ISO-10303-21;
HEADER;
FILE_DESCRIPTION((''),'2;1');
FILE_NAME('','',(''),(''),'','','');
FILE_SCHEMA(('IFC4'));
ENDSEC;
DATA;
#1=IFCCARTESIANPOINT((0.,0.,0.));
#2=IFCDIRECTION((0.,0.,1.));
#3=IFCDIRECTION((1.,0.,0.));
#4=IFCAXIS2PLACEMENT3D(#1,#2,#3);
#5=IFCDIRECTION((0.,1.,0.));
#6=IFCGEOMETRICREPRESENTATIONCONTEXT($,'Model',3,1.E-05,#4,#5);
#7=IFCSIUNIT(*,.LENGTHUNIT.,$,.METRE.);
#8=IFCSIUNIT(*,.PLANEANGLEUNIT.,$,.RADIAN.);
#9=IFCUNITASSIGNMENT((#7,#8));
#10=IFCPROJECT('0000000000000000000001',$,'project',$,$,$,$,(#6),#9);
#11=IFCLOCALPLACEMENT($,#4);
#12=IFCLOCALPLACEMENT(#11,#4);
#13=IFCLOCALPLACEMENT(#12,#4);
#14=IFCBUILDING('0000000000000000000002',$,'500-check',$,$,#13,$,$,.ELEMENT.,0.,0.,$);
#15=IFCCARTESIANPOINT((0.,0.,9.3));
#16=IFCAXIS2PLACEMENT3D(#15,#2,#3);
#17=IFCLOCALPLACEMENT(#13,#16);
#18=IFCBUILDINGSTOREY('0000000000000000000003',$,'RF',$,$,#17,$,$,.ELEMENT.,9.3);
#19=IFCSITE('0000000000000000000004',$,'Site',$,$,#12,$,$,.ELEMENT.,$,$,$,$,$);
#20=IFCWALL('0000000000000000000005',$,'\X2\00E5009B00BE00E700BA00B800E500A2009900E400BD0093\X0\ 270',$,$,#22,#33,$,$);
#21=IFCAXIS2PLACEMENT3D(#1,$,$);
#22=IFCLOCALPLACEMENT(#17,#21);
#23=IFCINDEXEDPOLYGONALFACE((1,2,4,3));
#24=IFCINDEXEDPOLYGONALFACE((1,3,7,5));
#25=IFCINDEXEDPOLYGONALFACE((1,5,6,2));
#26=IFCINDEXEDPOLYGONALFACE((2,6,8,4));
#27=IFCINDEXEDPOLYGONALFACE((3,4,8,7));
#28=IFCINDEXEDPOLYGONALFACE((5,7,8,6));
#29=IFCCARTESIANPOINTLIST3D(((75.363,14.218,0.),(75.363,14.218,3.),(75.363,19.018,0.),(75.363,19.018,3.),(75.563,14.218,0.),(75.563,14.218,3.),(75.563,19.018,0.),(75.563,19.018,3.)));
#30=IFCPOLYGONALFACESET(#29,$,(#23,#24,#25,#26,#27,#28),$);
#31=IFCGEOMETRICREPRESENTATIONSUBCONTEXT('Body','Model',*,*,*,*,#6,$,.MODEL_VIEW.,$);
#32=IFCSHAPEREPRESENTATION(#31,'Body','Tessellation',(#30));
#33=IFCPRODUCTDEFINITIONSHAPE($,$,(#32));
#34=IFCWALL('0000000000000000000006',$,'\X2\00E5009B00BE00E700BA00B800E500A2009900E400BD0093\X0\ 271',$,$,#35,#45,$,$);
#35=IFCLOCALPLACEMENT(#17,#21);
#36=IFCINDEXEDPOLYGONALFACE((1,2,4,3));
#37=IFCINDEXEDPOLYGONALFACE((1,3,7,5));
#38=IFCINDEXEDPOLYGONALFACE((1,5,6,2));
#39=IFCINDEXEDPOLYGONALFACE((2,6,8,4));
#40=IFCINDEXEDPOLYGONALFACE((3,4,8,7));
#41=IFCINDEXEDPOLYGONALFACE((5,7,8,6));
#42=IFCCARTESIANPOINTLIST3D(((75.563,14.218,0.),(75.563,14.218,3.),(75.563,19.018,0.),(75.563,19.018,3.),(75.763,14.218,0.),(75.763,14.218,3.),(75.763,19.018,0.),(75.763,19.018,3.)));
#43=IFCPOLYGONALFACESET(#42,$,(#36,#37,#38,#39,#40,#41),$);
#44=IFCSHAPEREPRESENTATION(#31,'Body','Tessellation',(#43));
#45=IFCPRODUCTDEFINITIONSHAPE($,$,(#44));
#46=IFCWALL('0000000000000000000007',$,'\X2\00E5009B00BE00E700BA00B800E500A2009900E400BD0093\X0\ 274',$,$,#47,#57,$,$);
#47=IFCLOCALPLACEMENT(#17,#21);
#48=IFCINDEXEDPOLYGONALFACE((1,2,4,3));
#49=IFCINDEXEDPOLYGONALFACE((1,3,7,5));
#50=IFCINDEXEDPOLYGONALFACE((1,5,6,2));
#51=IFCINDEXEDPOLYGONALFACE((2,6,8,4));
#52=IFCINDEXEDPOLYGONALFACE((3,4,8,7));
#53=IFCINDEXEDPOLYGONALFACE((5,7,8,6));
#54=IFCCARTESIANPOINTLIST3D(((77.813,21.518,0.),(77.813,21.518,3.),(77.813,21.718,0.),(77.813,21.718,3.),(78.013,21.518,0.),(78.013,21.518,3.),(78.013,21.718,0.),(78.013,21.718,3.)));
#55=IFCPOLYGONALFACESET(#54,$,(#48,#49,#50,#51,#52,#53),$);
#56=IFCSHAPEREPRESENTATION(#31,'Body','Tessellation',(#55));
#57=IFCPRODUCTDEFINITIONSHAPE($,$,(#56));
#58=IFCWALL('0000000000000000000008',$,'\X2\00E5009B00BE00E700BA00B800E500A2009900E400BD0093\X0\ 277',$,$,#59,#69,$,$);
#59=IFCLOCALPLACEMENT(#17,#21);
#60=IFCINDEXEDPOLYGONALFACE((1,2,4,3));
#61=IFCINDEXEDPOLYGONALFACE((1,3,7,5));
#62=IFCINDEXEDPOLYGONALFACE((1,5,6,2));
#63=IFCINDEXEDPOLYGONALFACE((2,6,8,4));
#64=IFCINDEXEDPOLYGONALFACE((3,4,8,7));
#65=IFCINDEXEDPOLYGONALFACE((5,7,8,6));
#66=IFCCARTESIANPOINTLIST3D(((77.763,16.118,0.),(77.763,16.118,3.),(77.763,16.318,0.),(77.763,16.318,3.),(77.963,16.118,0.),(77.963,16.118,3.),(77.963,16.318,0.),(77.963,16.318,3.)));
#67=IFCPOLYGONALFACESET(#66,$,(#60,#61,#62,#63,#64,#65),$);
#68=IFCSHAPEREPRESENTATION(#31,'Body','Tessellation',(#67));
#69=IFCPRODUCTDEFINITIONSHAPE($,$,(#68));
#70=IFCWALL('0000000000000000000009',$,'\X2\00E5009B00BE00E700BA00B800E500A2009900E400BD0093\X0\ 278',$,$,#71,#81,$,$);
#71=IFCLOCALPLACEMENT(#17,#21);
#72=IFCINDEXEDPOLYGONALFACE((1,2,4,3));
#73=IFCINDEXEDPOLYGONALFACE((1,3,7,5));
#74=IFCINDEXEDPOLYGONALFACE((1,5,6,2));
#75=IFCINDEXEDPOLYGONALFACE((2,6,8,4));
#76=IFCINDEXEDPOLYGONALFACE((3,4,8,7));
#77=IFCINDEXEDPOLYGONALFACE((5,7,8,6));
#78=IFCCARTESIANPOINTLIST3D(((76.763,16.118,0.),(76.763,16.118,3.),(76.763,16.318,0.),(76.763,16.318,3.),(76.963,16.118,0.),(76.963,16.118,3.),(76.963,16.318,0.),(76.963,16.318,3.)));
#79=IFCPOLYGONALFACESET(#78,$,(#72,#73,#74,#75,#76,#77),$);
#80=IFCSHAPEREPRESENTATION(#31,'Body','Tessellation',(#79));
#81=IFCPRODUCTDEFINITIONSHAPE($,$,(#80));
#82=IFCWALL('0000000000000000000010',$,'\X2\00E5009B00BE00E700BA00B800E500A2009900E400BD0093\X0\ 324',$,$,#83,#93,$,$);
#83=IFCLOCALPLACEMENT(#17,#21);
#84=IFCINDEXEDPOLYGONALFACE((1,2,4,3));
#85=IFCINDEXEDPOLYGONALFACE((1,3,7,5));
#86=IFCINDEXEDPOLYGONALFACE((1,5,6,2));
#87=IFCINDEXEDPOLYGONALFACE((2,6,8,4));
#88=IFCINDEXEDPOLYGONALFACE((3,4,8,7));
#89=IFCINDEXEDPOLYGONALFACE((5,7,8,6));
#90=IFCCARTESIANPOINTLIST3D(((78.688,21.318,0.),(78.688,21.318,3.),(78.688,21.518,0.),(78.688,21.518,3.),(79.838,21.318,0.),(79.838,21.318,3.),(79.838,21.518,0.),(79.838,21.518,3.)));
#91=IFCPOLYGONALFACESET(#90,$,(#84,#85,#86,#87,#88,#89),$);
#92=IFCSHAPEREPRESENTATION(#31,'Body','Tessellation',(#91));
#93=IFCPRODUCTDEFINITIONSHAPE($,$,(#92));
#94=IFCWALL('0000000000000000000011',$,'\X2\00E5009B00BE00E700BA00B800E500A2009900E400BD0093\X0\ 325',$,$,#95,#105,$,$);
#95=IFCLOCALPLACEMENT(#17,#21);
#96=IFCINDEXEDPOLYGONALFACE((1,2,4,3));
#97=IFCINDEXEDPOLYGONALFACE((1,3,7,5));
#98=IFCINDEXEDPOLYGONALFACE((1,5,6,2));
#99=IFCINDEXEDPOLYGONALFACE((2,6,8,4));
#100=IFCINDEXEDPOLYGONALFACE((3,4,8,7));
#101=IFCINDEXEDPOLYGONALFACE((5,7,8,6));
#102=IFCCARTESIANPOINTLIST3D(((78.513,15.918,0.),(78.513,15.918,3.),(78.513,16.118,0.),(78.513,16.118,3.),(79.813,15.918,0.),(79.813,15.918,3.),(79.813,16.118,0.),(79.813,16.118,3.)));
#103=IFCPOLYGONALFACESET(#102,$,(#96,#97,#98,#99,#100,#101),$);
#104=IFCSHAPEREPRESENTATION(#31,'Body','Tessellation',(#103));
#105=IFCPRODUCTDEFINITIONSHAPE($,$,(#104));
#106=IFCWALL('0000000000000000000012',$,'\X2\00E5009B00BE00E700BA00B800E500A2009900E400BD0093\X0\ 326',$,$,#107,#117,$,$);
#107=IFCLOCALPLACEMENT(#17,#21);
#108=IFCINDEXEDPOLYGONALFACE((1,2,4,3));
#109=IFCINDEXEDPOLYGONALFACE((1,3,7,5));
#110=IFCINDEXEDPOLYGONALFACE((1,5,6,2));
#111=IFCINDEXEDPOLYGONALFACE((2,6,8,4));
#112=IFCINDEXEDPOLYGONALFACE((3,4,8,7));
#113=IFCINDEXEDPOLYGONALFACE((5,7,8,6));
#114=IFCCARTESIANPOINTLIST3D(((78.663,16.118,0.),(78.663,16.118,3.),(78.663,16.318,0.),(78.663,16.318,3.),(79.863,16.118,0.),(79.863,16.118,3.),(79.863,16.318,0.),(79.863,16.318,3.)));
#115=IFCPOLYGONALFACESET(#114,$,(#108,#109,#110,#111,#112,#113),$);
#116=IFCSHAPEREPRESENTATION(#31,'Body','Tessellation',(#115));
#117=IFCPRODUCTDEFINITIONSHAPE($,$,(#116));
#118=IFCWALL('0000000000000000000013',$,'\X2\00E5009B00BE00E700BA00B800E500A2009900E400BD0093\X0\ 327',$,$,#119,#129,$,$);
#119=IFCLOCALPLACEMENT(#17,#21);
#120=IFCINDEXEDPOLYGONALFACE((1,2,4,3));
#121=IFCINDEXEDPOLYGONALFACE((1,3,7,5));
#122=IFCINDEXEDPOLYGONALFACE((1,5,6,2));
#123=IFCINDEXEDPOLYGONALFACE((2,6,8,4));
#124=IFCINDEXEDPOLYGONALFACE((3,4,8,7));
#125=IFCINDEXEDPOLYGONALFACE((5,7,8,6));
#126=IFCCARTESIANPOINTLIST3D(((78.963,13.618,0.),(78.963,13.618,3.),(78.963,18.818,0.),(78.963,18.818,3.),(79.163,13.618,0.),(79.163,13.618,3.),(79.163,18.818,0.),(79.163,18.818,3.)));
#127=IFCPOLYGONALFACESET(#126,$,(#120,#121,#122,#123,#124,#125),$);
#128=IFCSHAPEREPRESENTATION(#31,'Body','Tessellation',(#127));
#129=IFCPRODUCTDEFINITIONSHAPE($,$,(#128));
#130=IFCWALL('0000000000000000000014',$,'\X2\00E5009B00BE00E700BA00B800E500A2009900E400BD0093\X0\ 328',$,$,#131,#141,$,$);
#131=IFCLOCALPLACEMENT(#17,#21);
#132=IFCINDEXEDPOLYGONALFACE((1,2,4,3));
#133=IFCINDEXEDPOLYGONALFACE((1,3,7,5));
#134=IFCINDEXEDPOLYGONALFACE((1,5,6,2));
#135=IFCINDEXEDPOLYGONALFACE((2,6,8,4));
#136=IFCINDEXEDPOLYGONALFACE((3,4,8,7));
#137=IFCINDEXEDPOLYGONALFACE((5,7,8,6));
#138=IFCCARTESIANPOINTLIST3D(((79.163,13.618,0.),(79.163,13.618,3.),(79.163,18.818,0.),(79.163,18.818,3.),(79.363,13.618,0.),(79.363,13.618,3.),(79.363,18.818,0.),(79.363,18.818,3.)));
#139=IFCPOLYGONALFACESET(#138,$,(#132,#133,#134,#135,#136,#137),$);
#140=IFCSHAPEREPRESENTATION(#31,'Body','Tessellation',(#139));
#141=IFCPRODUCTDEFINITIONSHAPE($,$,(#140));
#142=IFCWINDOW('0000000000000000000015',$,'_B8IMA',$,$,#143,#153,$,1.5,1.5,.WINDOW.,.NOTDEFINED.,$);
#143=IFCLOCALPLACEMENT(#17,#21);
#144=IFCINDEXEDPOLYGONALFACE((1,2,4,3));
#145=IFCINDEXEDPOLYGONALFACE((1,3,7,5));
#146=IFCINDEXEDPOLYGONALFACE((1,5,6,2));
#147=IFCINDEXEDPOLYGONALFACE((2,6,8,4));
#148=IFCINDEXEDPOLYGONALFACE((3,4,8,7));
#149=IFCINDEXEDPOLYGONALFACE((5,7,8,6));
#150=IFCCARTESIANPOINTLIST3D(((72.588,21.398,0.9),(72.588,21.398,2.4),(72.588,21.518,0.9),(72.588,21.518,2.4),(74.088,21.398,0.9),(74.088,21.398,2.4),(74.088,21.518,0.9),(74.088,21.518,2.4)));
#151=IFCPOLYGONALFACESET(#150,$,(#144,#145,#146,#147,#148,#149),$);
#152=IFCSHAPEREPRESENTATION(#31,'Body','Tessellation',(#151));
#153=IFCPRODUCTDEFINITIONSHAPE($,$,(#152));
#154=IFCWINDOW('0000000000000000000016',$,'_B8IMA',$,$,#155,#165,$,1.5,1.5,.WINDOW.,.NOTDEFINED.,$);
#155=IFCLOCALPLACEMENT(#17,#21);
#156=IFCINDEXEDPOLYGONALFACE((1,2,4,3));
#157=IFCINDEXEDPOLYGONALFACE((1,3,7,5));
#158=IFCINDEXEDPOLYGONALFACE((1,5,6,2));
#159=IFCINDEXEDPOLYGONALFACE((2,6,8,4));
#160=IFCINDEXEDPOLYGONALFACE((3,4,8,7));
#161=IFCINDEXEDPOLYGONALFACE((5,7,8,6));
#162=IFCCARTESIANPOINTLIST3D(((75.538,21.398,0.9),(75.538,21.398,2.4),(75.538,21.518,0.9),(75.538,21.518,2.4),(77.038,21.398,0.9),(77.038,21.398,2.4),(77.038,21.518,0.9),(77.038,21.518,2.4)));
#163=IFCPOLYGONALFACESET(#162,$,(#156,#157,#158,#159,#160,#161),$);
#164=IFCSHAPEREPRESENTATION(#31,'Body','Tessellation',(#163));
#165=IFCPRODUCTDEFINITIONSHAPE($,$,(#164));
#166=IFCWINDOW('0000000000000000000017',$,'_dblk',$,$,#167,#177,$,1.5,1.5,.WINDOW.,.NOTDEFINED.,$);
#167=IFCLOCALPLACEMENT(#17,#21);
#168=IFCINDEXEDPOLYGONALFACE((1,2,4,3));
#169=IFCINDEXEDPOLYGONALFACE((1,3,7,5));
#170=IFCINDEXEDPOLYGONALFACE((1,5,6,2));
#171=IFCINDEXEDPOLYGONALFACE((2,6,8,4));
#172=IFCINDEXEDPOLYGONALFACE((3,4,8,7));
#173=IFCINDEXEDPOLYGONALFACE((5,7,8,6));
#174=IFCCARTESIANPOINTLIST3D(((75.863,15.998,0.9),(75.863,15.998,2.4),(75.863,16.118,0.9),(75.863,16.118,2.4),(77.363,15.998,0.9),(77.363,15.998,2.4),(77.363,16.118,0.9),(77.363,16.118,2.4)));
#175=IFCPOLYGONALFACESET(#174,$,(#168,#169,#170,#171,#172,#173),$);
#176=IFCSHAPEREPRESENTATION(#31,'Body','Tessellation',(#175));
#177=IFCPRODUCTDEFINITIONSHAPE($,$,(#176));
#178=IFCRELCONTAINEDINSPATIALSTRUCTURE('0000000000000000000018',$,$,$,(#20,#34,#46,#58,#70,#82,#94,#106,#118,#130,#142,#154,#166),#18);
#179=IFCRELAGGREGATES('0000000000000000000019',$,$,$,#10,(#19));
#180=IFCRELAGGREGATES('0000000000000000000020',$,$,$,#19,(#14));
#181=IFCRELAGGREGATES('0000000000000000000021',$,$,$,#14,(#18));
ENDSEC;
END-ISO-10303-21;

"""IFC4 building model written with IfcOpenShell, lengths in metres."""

from ifc_helpers import new_model, si_unit, direction, frame, frame_2d, origin_with_axes, place, context, subcontext, project, spatial, rectangle, extrude, element, save


model = new_model("IFC4")

# Units and contexts
model_context = context("Model", 3, precision=1e-05, world=origin_with_axes(), true_north=direction((0.0, 1.0, 0.0)))
body_context = subcontext(model_context, "Body", "Model", "MODEL_VIEW")
ifc_project = project(units=[si_unit("LENGTHUNIT", "METRE"), si_unit("PLANEANGLEUNIT", "RADIAN")], contexts=[model_context])

# Site, building, storey
placement = place(None, origin_with_axes())
site_placement = place(placement, origin_with_axes())
site = spatial("IfcSite", under=ifc_project, at=site_placement, Name="Site", CompositionType="ELEMENT")
building_placement = place(site_placement, origin_with_axes())
building = spatial("IfcBuilding", under=site, at=building_placement, Name="500-check", CompositionType="ELEMENT", ElevationOfRefHeight=0.0, ElevationOfTerrain=0.0)
storey_placement = place(building_placement, frame((0.0, 0.0, 9.3), z_axis=(0.0, 0.0, 1.0), x_axis=(1.0, 0.0, 0.0)))
storey = spatial("IfcBuildingStorey", under=building, at=storey_placement, Name="RF", CompositionType="ELEMENT", Elevation=9.3)

# Walls
for number, where, z_axis, x_axis, name in (
    (1, (75.463, 16.618, 0.0), (0.0, 0.0, 1.0), (0.0, 1.0, 0.0), "å\u009b¾çº¸å¢\u0099ä½\u0093 270"),
    (2, (75.663, 16.618, 0.0), (0.0, 0.0, 1.0), (0.0, 1.0, 0.0), "å\u009b¾çº¸å¢\u0099ä½\u0093 271"),
):
    element("IfcWall", number, at=place(storey_placement, frame(where, z_axis=z_axis, x_axis=x_axis)), inside=storey, Name=name, context=body_context, shape_type="SweptSolid", body=[
        extrude(rectangle(XDim=4.8, YDim=0.2, at=frame_2d((0.0, 0.0), x_axis=(1.0, 0.0, 0.0))), frame((0.0, 0.0, 0.0), z_axis=(0.0, 0.0, 1.0)), (0.0, 0.0, 1.0), 3.0),
    ])
for number, where, z_axis, x_axis, name in (
    (3, (77.913, 21.618, 0.0), (0.0, 0.0, 1.0), (0.0, -1.0, 0.0), "å\u009b¾çº¸å¢\u0099ä½\u0093 274"),
    (4, (77.863, 16.218, 0.0), (0.0, 0.0, 1.0), (0.0, -1.0, 0.0), "å\u009b¾çº¸å¢\u0099ä½\u0093 277"),
    (5, (76.863, 16.218, 0.0), (0.0, 0.0, 1.0), (0.0, -1.0, 0.0), "å\u009b¾çº¸å¢\u0099ä½\u0093 278"),
):
    element("IfcWall", number, at=place(storey_placement, frame(where, z_axis=z_axis, x_axis=x_axis)), inside=storey, Name=name, context=body_context, shape_type="SweptSolid", body=[
        extrude(rectangle(XDim=0.2, YDim=0.2, at=frame_2d((0.0, 0.0), x_axis=(1.0, 0.0, 0.0))), frame((0.0, 0.0, 0.0), z_axis=(0.0, 0.0, 1.0)), (0.0, 0.0, 1.0), 3.0),
    ])
wall_1_placement = place(storey_placement, frame((79.263, 21.418, 0.0), z_axis=(0.0, 0.0, 1.0), x_axis=(1.0, 0.0, 0.0)))
element("IfcWall", 6, at=wall_1_placement, inside=storey, Name="å\u009b¾çº¸å¢\u0099ä½\u0093 324", context=body_context, shape_type="SweptSolid", body=[
    extrude(rectangle(XDim=1.15, YDim=0.2, at=frame_2d((0.0, 0.0), x_axis=(1.0, 0.0, 0.0))), frame((0.0, 0.0, 0.0), z_axis=(0.0, 0.0, 1.0)), (0.0, 0.0, 1.0), 3.0),
])
wall_2_placement = place(storey_placement, frame((79.163, 16.018, 0.0), z_axis=(0.0, 0.0, 1.0), x_axis=(1.0, 0.0, 0.0)))
element("IfcWall", 7, at=wall_2_placement, inside=storey, Name="å\u009b¾çº¸å¢\u0099ä½\u0093 325", context=body_context, shape_type="SweptSolid", body=[
    extrude(rectangle(XDim=1.3, YDim=0.2, at=frame_2d((0.0, 0.0), x_axis=(1.0, 0.0, 0.0))), frame((0.0, 0.0, 0.0), z_axis=(0.0, 0.0, 1.0)), (0.0, 0.0, 1.0), 3.0),
])
wall_3_placement = place(storey_placement, frame((79.263, 16.218, 0.0), z_axis=(0.0, 0.0, 1.0), x_axis=(1.0, 0.0, 0.0)))
element("IfcWall", 8, at=wall_3_placement, inside=storey, Name="å\u009b¾çº¸å¢\u0099ä½\u0093 326", context=body_context, shape_type="SweptSolid", body=[
    extrude(rectangle(XDim=1.2, YDim=0.2, at=frame_2d((0.0, 0.0), x_axis=(1.0, 0.0, 0.0))), frame((0.0, 0.0, 0.0), z_axis=(0.0, 0.0, 1.0)), (0.0, 0.0, 1.0), 3.0),
])
for number, where, z_axis, x_axis, name in (
    (9, (79.063, 16.218, 0.0), (0.0, 0.0, 1.0), (0.0, 1.0, 0.0), "å\u009b¾çº¸å¢\u0099ä½\u0093 327"),
    (10, (79.263, 16.218, 0.0), (0.0, 0.0, 1.0), (0.0, 1.0, 0.0), "å\u009b¾çº¸å¢\u0099ä½\u0093 328"),
):
    element("IfcWall", number, at=place(storey_placement, frame(where, z_axis=z_axis, x_axis=x_axis)), inside=storey, Name=name, context=body_context, shape_type="SweptSolid", body=[
        extrude(rectangle(XDim=5.2, YDim=0.2, at=frame_2d((0.0, 0.0), x_axis=(1.0, 0.0, 0.0))), frame((0.0, 0.0, 0.0), z_axis=(0.0, 0.0, 1.0)), (0.0, 0.0, 1.0), 3.0),
    ])

# Windows
for number, where, z_axis, x_axis, name in (
    (11, (73.338, 21.458, 0.9), (0.0, 0.0, 1.0), (1.0, 0.0, 0.0), "_B8IMA"),
    (12, (76.288, 21.458, 0.9), (0.0, 0.0, 1.0), (1.0, 0.0, 0.0), "_B8IMA"),
    (13, (76.613, 16.058, 0.9), (0.0, 0.0, 1.0), (1.0, 0.0, 0.0), "_dblk"),
):
    element("IfcWindow", number, at=place(storey_placement, frame(where, z_axis=z_axis, x_axis=x_axis)), inside=storey, Name=name, OverallHeight=1.5, OverallWidth=1.5, PartitioningType="NOTDEFINED", PredefinedType="WINDOW", context=body_context, shape_type="SweptSolid", body=[
        extrude(rectangle(XDim=1.5, YDim=0.12, at=frame_2d((0.0, 0.0), x_axis=(1.0, 0.0, 0.0))), frame((0.0, 0.0, 0.0), z_axis=(0.0, 0.0, 1.0)), (0.0, 0.0, 1.0), 1.5),
    ])

save(model, "model.ifc")
